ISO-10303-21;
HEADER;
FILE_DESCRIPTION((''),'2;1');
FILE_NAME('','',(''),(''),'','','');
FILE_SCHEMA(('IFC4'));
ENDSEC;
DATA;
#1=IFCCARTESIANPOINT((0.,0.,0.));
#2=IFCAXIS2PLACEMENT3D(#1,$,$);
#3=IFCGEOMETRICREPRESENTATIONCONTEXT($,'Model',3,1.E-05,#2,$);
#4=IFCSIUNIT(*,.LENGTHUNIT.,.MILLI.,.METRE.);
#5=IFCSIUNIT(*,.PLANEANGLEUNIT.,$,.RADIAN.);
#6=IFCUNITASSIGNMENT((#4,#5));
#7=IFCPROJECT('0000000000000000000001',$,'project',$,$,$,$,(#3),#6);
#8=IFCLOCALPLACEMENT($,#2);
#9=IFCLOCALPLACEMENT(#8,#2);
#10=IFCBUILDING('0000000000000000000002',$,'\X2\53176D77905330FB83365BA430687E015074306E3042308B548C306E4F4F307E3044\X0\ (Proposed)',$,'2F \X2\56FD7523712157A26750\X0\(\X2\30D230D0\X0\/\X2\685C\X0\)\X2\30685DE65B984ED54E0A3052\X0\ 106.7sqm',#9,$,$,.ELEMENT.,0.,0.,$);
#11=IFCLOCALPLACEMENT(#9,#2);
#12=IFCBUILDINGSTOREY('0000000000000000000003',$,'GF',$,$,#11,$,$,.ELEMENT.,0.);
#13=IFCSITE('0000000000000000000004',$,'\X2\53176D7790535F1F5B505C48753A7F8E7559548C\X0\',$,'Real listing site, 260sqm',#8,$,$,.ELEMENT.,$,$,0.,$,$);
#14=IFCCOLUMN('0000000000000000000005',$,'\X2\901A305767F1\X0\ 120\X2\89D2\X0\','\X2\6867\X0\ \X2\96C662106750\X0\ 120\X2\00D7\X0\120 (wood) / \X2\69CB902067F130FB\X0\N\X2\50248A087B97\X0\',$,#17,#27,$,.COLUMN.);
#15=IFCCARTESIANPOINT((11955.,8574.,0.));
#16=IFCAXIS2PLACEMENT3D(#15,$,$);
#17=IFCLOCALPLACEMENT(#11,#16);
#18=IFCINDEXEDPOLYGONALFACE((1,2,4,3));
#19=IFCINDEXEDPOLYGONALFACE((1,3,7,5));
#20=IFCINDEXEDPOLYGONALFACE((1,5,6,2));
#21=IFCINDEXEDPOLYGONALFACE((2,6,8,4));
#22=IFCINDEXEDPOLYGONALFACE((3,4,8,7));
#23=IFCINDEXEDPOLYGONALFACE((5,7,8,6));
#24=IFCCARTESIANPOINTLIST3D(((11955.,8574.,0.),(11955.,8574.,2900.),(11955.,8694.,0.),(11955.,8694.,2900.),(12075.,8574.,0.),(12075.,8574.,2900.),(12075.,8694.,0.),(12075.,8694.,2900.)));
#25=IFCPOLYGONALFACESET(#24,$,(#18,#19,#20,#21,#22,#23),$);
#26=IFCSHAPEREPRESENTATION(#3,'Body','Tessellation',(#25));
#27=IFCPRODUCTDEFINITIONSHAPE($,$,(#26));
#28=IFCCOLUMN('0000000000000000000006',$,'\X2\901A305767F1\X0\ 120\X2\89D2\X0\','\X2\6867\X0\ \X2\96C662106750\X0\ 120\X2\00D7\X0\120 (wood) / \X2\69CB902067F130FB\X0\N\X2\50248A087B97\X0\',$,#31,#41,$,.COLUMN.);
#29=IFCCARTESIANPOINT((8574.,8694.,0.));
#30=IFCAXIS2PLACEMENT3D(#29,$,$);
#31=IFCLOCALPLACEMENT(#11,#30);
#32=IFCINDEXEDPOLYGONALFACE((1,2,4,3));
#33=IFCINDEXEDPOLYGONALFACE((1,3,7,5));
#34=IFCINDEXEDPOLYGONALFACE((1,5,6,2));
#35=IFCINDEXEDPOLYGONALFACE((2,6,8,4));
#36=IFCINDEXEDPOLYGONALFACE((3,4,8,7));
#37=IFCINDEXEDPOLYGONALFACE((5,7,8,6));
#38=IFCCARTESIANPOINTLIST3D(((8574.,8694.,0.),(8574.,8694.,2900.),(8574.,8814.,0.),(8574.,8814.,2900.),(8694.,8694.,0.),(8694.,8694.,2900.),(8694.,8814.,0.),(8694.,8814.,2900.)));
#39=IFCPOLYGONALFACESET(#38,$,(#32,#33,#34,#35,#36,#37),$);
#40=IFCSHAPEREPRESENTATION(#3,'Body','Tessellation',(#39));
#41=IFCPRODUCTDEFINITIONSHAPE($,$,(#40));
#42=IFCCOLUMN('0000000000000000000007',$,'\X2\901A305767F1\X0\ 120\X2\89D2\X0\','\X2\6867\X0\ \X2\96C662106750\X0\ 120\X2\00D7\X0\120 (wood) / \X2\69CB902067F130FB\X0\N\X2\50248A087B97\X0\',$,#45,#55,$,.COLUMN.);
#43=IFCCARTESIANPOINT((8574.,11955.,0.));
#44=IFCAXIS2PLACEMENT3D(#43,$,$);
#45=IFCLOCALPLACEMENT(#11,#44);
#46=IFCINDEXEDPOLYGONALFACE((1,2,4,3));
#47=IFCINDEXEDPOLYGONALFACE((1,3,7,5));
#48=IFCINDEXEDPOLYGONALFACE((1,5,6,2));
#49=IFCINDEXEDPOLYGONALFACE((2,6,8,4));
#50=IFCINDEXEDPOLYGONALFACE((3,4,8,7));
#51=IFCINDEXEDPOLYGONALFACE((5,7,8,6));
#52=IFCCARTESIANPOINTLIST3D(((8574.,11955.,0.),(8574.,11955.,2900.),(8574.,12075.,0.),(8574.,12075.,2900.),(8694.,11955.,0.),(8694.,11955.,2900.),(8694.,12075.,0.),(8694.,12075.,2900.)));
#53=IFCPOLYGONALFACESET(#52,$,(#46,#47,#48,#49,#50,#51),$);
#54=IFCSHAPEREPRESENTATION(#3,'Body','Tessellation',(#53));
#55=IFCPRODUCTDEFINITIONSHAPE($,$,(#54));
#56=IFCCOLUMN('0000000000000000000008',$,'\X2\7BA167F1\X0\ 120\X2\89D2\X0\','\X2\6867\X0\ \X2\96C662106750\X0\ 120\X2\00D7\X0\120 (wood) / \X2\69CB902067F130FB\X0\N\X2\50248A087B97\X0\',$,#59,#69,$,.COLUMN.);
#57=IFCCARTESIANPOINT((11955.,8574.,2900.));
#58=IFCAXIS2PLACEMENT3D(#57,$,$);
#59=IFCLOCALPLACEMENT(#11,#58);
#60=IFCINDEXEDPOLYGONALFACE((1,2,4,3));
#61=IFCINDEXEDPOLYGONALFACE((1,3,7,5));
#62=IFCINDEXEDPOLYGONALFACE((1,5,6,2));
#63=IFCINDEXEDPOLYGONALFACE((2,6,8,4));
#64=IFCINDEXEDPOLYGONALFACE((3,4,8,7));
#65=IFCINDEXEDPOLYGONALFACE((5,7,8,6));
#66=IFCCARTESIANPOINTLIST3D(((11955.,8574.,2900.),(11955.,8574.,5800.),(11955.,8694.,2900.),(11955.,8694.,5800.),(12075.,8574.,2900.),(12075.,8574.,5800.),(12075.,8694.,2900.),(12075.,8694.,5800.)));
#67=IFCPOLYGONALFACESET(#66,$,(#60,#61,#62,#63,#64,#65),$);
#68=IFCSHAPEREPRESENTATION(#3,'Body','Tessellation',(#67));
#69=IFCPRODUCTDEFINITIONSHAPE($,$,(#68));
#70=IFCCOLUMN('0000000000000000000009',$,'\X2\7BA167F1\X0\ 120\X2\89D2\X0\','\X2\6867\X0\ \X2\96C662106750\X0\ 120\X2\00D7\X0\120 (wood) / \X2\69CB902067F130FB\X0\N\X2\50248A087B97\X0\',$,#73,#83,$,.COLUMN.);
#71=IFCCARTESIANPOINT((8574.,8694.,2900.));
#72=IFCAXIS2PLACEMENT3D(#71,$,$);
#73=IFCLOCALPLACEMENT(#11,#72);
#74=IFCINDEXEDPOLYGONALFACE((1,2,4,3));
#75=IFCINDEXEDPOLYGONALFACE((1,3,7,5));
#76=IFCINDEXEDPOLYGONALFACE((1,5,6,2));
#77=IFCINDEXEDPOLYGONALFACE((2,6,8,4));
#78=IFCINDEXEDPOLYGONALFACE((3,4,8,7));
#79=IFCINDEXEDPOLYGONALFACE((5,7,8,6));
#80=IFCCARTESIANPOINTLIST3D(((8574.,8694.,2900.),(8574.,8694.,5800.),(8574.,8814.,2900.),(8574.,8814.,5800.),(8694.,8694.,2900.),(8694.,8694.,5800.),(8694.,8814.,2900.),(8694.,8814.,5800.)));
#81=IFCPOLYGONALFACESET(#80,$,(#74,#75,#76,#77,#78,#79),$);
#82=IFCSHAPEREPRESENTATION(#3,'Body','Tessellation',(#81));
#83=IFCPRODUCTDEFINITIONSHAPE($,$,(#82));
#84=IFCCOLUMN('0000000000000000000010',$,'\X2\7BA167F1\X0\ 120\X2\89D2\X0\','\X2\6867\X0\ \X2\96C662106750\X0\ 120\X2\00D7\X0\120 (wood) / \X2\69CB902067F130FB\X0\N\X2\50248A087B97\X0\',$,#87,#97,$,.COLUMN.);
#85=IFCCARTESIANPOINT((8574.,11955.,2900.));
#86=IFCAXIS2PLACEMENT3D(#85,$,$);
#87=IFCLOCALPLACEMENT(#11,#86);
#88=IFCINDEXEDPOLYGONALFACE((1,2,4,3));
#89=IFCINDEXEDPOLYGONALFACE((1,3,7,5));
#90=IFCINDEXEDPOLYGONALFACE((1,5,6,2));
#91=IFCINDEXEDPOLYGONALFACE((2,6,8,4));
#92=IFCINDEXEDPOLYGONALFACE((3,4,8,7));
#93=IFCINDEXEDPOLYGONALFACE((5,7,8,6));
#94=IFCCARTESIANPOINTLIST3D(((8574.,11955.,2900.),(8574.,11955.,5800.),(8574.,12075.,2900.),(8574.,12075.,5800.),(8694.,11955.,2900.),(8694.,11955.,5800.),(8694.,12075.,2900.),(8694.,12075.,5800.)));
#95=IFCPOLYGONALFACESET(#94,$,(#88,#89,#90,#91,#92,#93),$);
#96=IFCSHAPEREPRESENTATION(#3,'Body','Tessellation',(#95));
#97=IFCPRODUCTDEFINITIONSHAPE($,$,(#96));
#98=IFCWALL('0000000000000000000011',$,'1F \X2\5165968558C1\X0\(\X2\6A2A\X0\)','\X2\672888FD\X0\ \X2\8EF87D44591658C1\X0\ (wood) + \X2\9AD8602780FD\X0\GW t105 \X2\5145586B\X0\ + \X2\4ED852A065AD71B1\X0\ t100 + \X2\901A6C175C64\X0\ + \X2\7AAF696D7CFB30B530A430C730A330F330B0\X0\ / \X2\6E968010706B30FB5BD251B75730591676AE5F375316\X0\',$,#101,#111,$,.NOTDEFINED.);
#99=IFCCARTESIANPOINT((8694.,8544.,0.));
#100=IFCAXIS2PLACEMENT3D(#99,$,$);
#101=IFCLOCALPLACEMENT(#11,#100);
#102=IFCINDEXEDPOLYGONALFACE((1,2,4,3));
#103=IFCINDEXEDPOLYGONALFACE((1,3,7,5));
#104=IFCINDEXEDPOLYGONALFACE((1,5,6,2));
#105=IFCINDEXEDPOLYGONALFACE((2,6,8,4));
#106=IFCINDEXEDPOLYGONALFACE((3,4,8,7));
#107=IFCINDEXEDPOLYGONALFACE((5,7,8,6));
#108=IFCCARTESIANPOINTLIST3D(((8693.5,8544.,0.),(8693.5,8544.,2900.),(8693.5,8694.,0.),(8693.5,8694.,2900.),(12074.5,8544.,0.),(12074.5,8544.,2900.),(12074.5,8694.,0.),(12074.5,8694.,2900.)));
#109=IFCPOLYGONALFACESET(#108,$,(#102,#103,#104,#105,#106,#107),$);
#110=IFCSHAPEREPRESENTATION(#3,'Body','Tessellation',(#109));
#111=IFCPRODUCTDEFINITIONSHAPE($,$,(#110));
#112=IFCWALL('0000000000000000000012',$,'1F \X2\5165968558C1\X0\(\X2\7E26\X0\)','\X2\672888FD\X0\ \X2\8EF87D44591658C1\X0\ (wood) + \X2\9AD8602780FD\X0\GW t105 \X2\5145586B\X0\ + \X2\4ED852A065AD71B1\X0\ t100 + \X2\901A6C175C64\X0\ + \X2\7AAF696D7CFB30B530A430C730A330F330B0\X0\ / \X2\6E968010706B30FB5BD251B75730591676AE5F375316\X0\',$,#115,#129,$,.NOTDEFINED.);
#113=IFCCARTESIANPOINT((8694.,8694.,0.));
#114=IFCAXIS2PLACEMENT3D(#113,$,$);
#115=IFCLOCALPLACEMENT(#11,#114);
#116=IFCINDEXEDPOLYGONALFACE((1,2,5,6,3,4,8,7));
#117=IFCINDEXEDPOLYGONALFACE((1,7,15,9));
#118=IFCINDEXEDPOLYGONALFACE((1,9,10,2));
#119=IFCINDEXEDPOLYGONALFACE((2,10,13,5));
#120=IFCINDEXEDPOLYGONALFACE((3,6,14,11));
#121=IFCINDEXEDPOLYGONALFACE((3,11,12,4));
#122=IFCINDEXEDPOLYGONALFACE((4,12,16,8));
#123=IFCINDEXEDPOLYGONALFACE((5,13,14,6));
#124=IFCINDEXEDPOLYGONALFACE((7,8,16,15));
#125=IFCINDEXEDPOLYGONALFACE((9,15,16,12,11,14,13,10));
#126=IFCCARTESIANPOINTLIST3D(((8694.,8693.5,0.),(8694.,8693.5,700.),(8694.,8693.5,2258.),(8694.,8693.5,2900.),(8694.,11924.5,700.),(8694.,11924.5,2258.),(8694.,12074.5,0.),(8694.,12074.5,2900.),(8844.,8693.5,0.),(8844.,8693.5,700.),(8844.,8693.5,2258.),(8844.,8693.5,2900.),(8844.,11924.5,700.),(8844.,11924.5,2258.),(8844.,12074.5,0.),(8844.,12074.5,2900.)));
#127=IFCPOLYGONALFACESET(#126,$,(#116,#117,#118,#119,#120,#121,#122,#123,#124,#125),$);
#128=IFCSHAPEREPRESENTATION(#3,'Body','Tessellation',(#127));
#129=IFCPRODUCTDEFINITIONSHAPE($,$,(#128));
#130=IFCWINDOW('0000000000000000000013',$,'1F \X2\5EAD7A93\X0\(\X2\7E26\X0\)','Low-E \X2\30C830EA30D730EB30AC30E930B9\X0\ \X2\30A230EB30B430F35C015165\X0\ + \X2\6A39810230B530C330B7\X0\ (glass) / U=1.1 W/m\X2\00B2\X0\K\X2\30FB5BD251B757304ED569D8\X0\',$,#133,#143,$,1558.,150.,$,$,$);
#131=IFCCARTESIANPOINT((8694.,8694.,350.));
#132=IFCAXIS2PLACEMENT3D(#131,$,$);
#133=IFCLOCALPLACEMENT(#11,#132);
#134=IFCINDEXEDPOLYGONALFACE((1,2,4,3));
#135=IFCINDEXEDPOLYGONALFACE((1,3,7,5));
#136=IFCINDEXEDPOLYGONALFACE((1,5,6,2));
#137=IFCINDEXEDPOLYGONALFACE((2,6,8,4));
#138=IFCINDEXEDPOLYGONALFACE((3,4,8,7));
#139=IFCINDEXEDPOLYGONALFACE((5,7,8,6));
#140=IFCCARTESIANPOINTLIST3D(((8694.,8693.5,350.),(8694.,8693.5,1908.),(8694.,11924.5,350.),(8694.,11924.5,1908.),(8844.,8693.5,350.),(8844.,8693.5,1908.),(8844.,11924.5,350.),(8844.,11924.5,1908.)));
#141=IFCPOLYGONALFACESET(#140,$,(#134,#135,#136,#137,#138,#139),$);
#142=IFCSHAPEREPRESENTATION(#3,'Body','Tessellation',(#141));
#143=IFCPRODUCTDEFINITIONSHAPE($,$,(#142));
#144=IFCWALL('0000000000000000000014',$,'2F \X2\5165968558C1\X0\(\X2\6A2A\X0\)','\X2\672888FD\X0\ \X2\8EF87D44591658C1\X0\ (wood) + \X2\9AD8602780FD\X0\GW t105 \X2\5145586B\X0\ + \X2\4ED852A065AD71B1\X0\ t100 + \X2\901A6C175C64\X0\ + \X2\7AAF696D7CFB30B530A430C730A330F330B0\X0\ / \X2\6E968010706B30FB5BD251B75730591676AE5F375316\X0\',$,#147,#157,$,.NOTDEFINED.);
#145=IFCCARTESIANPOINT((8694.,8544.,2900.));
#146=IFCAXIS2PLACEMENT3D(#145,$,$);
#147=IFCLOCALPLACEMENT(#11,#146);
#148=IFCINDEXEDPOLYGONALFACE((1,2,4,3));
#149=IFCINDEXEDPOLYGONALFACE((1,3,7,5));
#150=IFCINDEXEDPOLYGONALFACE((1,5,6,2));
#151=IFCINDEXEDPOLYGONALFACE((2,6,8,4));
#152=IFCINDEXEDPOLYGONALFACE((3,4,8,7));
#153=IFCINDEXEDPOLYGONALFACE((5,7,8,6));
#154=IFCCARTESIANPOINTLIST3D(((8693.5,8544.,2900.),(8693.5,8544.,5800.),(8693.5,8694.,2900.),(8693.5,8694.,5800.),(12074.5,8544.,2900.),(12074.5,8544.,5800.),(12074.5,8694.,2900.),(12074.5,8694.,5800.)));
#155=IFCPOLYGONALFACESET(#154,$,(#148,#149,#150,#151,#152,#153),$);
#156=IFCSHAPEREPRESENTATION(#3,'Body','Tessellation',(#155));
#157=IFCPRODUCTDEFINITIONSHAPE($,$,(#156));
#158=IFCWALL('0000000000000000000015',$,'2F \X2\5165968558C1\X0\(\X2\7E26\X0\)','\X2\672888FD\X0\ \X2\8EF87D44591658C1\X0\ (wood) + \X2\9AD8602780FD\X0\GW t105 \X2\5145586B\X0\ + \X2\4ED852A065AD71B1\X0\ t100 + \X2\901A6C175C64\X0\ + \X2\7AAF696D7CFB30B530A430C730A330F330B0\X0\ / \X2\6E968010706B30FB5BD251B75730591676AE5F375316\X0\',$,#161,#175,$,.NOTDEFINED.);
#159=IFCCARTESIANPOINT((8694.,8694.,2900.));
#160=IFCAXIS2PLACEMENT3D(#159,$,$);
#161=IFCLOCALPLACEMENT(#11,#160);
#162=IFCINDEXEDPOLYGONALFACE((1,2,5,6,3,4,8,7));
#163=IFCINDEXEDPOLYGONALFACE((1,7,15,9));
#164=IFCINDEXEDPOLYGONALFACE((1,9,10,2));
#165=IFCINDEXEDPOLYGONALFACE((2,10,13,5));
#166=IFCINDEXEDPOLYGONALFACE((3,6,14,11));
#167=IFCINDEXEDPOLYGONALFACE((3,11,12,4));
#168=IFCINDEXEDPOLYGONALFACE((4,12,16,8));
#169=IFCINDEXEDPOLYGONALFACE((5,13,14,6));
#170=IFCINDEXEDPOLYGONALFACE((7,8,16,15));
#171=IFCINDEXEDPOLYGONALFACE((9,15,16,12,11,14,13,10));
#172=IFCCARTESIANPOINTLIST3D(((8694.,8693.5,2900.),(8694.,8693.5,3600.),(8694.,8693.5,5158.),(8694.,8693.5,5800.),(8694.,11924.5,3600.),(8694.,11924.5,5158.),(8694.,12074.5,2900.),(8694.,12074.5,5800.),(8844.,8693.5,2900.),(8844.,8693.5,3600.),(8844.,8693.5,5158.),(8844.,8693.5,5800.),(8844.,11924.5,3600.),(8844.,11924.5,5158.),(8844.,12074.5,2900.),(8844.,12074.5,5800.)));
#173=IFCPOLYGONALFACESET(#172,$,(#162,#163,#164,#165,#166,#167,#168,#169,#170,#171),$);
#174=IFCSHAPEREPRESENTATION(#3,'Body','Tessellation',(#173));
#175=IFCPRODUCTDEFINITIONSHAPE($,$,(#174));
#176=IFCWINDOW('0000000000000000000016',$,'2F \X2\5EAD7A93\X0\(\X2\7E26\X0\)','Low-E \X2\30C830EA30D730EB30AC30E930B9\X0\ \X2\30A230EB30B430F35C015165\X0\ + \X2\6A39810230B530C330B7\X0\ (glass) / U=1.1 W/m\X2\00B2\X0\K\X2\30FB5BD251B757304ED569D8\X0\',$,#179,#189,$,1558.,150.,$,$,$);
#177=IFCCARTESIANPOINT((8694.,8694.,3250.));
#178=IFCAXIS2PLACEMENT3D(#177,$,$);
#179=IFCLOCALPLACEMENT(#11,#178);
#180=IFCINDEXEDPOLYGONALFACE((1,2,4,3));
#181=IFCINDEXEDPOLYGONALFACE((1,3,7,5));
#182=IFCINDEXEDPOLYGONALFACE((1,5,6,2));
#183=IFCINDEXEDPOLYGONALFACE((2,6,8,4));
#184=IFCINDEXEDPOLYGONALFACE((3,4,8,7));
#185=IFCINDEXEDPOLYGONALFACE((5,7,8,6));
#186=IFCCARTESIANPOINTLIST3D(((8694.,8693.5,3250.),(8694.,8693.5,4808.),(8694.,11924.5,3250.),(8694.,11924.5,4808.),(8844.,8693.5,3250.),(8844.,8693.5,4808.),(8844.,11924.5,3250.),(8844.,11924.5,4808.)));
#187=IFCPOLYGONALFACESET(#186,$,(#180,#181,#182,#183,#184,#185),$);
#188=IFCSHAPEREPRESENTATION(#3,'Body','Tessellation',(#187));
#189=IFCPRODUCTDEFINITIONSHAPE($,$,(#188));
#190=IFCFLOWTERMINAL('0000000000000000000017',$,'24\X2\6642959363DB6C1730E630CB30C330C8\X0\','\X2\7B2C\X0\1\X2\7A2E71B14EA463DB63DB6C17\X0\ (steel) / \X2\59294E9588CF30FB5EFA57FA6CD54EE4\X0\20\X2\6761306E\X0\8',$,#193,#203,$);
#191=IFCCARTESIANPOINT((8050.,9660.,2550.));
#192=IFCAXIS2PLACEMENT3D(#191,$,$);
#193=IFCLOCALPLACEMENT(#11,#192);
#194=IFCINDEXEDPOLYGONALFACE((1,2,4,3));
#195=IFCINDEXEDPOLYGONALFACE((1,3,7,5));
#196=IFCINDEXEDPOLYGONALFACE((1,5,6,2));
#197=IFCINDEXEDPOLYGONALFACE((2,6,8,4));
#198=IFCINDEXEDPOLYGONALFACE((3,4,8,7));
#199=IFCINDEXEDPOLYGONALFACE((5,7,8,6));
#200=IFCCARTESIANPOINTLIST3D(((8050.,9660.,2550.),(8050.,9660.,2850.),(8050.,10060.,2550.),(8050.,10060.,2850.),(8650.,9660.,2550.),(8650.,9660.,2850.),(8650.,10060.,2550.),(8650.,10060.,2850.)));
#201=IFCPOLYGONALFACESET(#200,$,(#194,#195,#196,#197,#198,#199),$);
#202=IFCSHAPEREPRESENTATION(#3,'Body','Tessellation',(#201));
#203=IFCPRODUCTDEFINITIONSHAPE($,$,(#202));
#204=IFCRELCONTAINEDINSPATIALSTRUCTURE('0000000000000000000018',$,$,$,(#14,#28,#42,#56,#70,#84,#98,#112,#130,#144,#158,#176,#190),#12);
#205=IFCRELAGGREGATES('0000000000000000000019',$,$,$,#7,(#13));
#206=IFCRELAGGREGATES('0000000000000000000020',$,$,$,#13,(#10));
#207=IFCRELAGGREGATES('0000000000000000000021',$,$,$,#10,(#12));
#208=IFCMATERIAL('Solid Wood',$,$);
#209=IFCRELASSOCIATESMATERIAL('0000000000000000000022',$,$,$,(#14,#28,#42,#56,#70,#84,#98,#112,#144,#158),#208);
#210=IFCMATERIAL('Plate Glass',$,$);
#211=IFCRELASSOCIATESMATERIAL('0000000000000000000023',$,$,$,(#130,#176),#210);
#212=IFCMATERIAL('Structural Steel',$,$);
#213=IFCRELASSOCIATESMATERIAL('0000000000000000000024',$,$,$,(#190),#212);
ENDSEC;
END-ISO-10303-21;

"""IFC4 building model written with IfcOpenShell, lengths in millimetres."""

from ifc_helpers import new_model, si_unit, frame, frame_2d, origin, place, context, project, spatial, rectangle, extrude, material, element, fill, save


model = new_model("IFC4")

# Units and contexts
model_context = context("Model", 3, precision=1e-05, world=origin())
ifc_project = project(units=[si_unit("LENGTHUNIT", "METRE", prefix="MILLI"), si_unit("PLANEANGLEUNIT", "RADIAN")], contexts=[model_context])

# Site, building, storey
site_placement = place(None, origin())
site = spatial("IfcSite", under=ifc_project, at=site_placement, Name="北海道弟子屈町美留和", ObjectType="Real listing site, 260sqm", CompositionType="ELEMENT", RefElevation=0.0)
building_placement = place(site_placement, origin())
building = spatial("IfcBuilding", under=site, at=building_placement, Name="北海道・茶室と縁側のある和の住まい (Proposed)", ObjectType="2F 国産無垢材(ヒバ/桜)と左官仕上げ 106.7sqm", CompositionType="ELEMENT", ElevationOfRefHeight=0.0, ElevationOfTerrain=0.0)
storey_placement = place(building_placement, origin())
storey = spatial("IfcBuildingStorey", under=building, at=storey_placement, Name="GF", CompositionType="ELEMENT", Elevation=0.0)

# Columns
ifc_material_1 = material(Name="Solid Wood")
column_1_placement = place(storey_placement, frame((11955.0, 8574.0, 0.0)))
element("IfcColumn", 1, at=column_1_placement, inside=storey, material=ifc_material_1, Name="通し柱 120角", Description="桧 集成材 120×120 (wood) / 構造柱・N値計算", PredefinedType="COLUMN", context=model_context, shape_type="SweptSolid", body=[
    extrude(rectangle(XDim=120.0, YDim=120.0, at=frame_2d((60.0, 60.0))), frame((11955.0, 8574.0, 0.0)), (0.0, 0.0, 1.0), 2900.0),
])
column_2_placement = place(storey_placement, frame((8574.0, 8694.0, 0.0)))
element("IfcColumn", 2, at=column_2_placement, inside=storey, material=ifc_material_1, Name="通し柱 120角", Description="桧 集成材 120×120 (wood) / 構造柱・N値計算", PredefinedType="COLUMN", context=model_context, shape_type="SweptSolid", body=[
    extrude(rectangle(XDim=120.0, YDim=120.0, at=frame_2d((60.0, 60.0))), frame((8574.0, 8694.0, 0.0)), (0.0, 0.0, 1.0), 2900.0),
])
column_3_placement = place(storey_placement, frame((8574.0, 11955.0, 0.0)))
element("IfcColumn", 3, at=column_3_placement, inside=storey, material=ifc_material_1, Name="通し柱 120角", Description="桧 集成材 120×120 (wood) / 構造柱・N値計算", PredefinedType="COLUMN", context=model_context, shape_type="SweptSolid", body=[
    extrude(rectangle(XDim=120.0, YDim=120.0, at=frame_2d((60.0, 60.0))), frame((8574.0, 11955.0, 0.0)), (0.0, 0.0, 1.0), 2900.0),
])
column_4_placement = place(storey_placement, frame((11955.0, 8574.0, 2900.0)))
element("IfcColumn", 4, at=column_4_placement, inside=storey, material=ifc_material_1, Name="管柱 120角", Description="桧 集成材 120×120 (wood) / 構造柱・N値計算", PredefinedType="COLUMN", context=model_context, shape_type="SweptSolid", body=[
    extrude(rectangle(XDim=120.0, YDim=120.0, at=frame_2d((60.0, 60.0))), frame((11955.0, 8574.0, 2900.0)), (0.0, 0.0, 1.0), 2900.0),
])
column_5_placement = place(storey_placement, frame((8574.0, 8694.0, 2900.0)))
element("IfcColumn", 5, at=column_5_placement, inside=storey, material=ifc_material_1, Name="管柱 120角", Description="桧 集成材 120×120 (wood) / 構造柱・N値計算", PredefinedType="COLUMN", context=model_context, shape_type="SweptSolid", body=[
    extrude(rectangle(XDim=120.0, YDim=120.0, at=frame_2d((60.0, 60.0))), frame((8574.0, 8694.0, 2900.0)), (0.0, 0.0, 1.0), 2900.0),
])
column_6_placement = place(storey_placement, frame((8574.0, 11955.0, 2900.0)))
element("IfcColumn", 6, at=column_6_placement, inside=storey, material=ifc_material_1, Name="管柱 120角", Description="桧 集成材 120×120 (wood) / 構造柱・N値計算", PredefinedType="COLUMN", context=model_context, shape_type="SweptSolid", body=[
    extrude(rectangle(XDim=120.0, YDim=120.0, at=frame_2d((60.0, 60.0))), frame((8574.0, 11955.0, 2900.0)), (0.0, 0.0, 1.0), 2900.0),
])

# Wall
wall_1_placement = place(storey_placement, frame((8694.0, 8544.0, 0.0)))
element("IfcWall", 7, at=wall_1_placement, inside=storey, material=ifc_material_1, Name="1F 入隅壁(横)", Description="木製 軸組外壁 (wood) + 高性能GW t105 充填 + 付加断熱 t100 + 通気層 + 窯業系サイディング / 準耐火・寒冷地外皮強化", PredefinedType="NOTDEFINED", context=model_context, shape_type="SweptSolid", body=[
    extrude(rectangle(XDim=3381.0, YDim=150.0, at=frame_2d((1690.0, 75.0))), frame((8694.0, 8544.0, 0.0)), (0.0, 0.0, 1.0), 2900.0),
])

# Wall, opening, window
wall_2_placement = place(storey_placement, frame((8694.0, 8694.0, 0.0)))
wall_2 = element("IfcWall", 8, at=wall_2_placement, inside=storey, material=ifc_material_1, Name="1F 入隅壁(縦)", Description="木製 軸組外壁 (wood) + 高性能GW t105 充填 + 付加断熱 t100 + 通気層 + 窯業系サイディング / 準耐火・寒冷地外皮強化", PredefinedType="NOTDEFINED", context=model_context, shape_type="SweptSolid", body=[
    extrude(rectangle(XDim=150.0, YDim=3381.0, at=frame_2d((75.0, 1690.0))), frame((8694.0, 8694.0, 0.0)), (0.0, 0.0, 1.0), 2900.0),
])
opening_1_placement = place(storey_placement, frame((8694.0, 8694.0, 350.0)))
opening_1 = element("IfcOpeningElement", 9, at=opening_1_placement, cuts=wall_2, PredefinedType="NOTDEFINED", context=model_context, shape_type="SweptSolid", body=[
    extrude(rectangle(XDim=150.0, YDim=3231.0, at=frame_2d((75.0, 1615.0))), frame((8694.0, 8694.0, 350.0)), (0.0, 0.0, 1.0), 1558.0),
])
ifc_material_2 = material(Name="Plate Glass")
window_1_placement = place(storey_placement, frame((8694.0, 8694.0, 350.0)))
window_1 = element("IfcWindow", 10, at=window_1_placement, inside=storey, material=ifc_material_2, Name="1F 庭窓(縦)", Description="Low-E トリプルガラス アルゴン封入 + 樹脂サッシ (glass) / U=1.1 W/m²K・寒冷地仕様", OverallHeight=1558.0, OverallWidth=150.0, context=model_context, shape_type="SweptSolid", body=[
    extrude(rectangle(XDim=150.0, YDim=3231.0, at=frame_2d((75.0, 1615.0))), frame((8694.0, 8694.0, 350.0)), (0.0, 0.0, 1.0), 1558.0),
])
fill(opening_1, window_1)

# Wall
wall_3_placement = place(storey_placement, frame((8694.0, 8544.0, 2900.0)))
element("IfcWall", 11, at=wall_3_placement, inside=storey, material=ifc_material_1, Name="2F 入隅壁(横)", Description="木製 軸組外壁 (wood) + 高性能GW t105 充填 + 付加断熱 t100 + 通気層 + 窯業系サイディング / 準耐火・寒冷地外皮強化", PredefinedType="NOTDEFINED", context=model_context, shape_type="SweptSolid", body=[
    extrude(rectangle(XDim=3381.0, YDim=150.0, at=frame_2d((1690.0, 75.0))), frame((8694.0, 8544.0, 2900.0)), (0.0, 0.0, 1.0), 2900.0),
])

# Wall, opening, window
wall_4_placement = place(storey_placement, frame((8694.0, 8694.0, 2900.0)))
wall_4 = element("IfcWall", 12, at=wall_4_placement, inside=storey, material=ifc_material_1, Name="2F 入隅壁(縦)", Description="木製 軸組外壁 (wood) + 高性能GW t105 充填 + 付加断熱 t100 + 通気層 + 窯業系サイディング / 準耐火・寒冷地外皮強化", PredefinedType="NOTDEFINED", context=model_context, shape_type="SweptSolid", body=[
    extrude(rectangle(XDim=150.0, YDim=3381.0, at=frame_2d((75.0, 1690.0))), frame((8694.0, 8694.0, 2900.0)), (0.0, 0.0, 1.0), 2900.0),
])
opening_2_placement = place(storey_placement, frame((8694.0, 8694.0, 3250.0)))
opening_2 = element("IfcOpeningElement", 13, at=opening_2_placement, cuts=wall_4, PredefinedType="NOTDEFINED", context=model_context, shape_type="SweptSolid", body=[
    extrude(rectangle(XDim=150.0, YDim=3231.0, at=frame_2d((75.0, 1615.0))), frame((8694.0, 8694.0, 3250.0)), (0.0, 0.0, 1.0), 1558.0),
])
window_2_placement = place(storey_placement, frame((8694.0, 8694.0, 3250.0)))
window_2 = element("IfcWindow", 14, at=window_2_placement, inside=storey, material=ifc_material_2, Name="2F 庭窓(縦)", Description="Low-E トリプルガラス アルゴン封入 + 樹脂サッシ (glass) / U=1.1 W/m²K・寒冷地仕様", OverallHeight=1558.0, OverallWidth=150.0, context=model_context, shape_type="SweptSolid", body=[
    extrude(rectangle(XDim=150.0, YDim=3231.0, at=frame_2d((75.0, 1615.0))), frame((8694.0, 8694.0, 3250.0)), (0.0, 0.0, 1.0), 1558.0),
])
fill(opening_2, window_2)

# Flow terminal
ifc_material_3 = material(Name="Structural Steel")
flow_terminal_placement = place(storey_placement, frame((8050.0, 9660.0, 2550.0)))
element("IfcFlowTerminal", 15, at=flow_terminal_placement, inside=storey, material=ifc_material_3, Name="24時間換気ユニット", Description="第1種熱交換換気 (steel) / 天井裏・建基法令20条の8", context=model_context, shape_type="SweptSolid", body=[
    extrude(rectangle(XDim=600.0, YDim=400.0, at=frame_2d((300.0, 200.0))), frame((8050.0, 9660.0, 2550.0)), (0.0, 0.0, 1.0), 300.0),
])

save(model, "model.ifc")
